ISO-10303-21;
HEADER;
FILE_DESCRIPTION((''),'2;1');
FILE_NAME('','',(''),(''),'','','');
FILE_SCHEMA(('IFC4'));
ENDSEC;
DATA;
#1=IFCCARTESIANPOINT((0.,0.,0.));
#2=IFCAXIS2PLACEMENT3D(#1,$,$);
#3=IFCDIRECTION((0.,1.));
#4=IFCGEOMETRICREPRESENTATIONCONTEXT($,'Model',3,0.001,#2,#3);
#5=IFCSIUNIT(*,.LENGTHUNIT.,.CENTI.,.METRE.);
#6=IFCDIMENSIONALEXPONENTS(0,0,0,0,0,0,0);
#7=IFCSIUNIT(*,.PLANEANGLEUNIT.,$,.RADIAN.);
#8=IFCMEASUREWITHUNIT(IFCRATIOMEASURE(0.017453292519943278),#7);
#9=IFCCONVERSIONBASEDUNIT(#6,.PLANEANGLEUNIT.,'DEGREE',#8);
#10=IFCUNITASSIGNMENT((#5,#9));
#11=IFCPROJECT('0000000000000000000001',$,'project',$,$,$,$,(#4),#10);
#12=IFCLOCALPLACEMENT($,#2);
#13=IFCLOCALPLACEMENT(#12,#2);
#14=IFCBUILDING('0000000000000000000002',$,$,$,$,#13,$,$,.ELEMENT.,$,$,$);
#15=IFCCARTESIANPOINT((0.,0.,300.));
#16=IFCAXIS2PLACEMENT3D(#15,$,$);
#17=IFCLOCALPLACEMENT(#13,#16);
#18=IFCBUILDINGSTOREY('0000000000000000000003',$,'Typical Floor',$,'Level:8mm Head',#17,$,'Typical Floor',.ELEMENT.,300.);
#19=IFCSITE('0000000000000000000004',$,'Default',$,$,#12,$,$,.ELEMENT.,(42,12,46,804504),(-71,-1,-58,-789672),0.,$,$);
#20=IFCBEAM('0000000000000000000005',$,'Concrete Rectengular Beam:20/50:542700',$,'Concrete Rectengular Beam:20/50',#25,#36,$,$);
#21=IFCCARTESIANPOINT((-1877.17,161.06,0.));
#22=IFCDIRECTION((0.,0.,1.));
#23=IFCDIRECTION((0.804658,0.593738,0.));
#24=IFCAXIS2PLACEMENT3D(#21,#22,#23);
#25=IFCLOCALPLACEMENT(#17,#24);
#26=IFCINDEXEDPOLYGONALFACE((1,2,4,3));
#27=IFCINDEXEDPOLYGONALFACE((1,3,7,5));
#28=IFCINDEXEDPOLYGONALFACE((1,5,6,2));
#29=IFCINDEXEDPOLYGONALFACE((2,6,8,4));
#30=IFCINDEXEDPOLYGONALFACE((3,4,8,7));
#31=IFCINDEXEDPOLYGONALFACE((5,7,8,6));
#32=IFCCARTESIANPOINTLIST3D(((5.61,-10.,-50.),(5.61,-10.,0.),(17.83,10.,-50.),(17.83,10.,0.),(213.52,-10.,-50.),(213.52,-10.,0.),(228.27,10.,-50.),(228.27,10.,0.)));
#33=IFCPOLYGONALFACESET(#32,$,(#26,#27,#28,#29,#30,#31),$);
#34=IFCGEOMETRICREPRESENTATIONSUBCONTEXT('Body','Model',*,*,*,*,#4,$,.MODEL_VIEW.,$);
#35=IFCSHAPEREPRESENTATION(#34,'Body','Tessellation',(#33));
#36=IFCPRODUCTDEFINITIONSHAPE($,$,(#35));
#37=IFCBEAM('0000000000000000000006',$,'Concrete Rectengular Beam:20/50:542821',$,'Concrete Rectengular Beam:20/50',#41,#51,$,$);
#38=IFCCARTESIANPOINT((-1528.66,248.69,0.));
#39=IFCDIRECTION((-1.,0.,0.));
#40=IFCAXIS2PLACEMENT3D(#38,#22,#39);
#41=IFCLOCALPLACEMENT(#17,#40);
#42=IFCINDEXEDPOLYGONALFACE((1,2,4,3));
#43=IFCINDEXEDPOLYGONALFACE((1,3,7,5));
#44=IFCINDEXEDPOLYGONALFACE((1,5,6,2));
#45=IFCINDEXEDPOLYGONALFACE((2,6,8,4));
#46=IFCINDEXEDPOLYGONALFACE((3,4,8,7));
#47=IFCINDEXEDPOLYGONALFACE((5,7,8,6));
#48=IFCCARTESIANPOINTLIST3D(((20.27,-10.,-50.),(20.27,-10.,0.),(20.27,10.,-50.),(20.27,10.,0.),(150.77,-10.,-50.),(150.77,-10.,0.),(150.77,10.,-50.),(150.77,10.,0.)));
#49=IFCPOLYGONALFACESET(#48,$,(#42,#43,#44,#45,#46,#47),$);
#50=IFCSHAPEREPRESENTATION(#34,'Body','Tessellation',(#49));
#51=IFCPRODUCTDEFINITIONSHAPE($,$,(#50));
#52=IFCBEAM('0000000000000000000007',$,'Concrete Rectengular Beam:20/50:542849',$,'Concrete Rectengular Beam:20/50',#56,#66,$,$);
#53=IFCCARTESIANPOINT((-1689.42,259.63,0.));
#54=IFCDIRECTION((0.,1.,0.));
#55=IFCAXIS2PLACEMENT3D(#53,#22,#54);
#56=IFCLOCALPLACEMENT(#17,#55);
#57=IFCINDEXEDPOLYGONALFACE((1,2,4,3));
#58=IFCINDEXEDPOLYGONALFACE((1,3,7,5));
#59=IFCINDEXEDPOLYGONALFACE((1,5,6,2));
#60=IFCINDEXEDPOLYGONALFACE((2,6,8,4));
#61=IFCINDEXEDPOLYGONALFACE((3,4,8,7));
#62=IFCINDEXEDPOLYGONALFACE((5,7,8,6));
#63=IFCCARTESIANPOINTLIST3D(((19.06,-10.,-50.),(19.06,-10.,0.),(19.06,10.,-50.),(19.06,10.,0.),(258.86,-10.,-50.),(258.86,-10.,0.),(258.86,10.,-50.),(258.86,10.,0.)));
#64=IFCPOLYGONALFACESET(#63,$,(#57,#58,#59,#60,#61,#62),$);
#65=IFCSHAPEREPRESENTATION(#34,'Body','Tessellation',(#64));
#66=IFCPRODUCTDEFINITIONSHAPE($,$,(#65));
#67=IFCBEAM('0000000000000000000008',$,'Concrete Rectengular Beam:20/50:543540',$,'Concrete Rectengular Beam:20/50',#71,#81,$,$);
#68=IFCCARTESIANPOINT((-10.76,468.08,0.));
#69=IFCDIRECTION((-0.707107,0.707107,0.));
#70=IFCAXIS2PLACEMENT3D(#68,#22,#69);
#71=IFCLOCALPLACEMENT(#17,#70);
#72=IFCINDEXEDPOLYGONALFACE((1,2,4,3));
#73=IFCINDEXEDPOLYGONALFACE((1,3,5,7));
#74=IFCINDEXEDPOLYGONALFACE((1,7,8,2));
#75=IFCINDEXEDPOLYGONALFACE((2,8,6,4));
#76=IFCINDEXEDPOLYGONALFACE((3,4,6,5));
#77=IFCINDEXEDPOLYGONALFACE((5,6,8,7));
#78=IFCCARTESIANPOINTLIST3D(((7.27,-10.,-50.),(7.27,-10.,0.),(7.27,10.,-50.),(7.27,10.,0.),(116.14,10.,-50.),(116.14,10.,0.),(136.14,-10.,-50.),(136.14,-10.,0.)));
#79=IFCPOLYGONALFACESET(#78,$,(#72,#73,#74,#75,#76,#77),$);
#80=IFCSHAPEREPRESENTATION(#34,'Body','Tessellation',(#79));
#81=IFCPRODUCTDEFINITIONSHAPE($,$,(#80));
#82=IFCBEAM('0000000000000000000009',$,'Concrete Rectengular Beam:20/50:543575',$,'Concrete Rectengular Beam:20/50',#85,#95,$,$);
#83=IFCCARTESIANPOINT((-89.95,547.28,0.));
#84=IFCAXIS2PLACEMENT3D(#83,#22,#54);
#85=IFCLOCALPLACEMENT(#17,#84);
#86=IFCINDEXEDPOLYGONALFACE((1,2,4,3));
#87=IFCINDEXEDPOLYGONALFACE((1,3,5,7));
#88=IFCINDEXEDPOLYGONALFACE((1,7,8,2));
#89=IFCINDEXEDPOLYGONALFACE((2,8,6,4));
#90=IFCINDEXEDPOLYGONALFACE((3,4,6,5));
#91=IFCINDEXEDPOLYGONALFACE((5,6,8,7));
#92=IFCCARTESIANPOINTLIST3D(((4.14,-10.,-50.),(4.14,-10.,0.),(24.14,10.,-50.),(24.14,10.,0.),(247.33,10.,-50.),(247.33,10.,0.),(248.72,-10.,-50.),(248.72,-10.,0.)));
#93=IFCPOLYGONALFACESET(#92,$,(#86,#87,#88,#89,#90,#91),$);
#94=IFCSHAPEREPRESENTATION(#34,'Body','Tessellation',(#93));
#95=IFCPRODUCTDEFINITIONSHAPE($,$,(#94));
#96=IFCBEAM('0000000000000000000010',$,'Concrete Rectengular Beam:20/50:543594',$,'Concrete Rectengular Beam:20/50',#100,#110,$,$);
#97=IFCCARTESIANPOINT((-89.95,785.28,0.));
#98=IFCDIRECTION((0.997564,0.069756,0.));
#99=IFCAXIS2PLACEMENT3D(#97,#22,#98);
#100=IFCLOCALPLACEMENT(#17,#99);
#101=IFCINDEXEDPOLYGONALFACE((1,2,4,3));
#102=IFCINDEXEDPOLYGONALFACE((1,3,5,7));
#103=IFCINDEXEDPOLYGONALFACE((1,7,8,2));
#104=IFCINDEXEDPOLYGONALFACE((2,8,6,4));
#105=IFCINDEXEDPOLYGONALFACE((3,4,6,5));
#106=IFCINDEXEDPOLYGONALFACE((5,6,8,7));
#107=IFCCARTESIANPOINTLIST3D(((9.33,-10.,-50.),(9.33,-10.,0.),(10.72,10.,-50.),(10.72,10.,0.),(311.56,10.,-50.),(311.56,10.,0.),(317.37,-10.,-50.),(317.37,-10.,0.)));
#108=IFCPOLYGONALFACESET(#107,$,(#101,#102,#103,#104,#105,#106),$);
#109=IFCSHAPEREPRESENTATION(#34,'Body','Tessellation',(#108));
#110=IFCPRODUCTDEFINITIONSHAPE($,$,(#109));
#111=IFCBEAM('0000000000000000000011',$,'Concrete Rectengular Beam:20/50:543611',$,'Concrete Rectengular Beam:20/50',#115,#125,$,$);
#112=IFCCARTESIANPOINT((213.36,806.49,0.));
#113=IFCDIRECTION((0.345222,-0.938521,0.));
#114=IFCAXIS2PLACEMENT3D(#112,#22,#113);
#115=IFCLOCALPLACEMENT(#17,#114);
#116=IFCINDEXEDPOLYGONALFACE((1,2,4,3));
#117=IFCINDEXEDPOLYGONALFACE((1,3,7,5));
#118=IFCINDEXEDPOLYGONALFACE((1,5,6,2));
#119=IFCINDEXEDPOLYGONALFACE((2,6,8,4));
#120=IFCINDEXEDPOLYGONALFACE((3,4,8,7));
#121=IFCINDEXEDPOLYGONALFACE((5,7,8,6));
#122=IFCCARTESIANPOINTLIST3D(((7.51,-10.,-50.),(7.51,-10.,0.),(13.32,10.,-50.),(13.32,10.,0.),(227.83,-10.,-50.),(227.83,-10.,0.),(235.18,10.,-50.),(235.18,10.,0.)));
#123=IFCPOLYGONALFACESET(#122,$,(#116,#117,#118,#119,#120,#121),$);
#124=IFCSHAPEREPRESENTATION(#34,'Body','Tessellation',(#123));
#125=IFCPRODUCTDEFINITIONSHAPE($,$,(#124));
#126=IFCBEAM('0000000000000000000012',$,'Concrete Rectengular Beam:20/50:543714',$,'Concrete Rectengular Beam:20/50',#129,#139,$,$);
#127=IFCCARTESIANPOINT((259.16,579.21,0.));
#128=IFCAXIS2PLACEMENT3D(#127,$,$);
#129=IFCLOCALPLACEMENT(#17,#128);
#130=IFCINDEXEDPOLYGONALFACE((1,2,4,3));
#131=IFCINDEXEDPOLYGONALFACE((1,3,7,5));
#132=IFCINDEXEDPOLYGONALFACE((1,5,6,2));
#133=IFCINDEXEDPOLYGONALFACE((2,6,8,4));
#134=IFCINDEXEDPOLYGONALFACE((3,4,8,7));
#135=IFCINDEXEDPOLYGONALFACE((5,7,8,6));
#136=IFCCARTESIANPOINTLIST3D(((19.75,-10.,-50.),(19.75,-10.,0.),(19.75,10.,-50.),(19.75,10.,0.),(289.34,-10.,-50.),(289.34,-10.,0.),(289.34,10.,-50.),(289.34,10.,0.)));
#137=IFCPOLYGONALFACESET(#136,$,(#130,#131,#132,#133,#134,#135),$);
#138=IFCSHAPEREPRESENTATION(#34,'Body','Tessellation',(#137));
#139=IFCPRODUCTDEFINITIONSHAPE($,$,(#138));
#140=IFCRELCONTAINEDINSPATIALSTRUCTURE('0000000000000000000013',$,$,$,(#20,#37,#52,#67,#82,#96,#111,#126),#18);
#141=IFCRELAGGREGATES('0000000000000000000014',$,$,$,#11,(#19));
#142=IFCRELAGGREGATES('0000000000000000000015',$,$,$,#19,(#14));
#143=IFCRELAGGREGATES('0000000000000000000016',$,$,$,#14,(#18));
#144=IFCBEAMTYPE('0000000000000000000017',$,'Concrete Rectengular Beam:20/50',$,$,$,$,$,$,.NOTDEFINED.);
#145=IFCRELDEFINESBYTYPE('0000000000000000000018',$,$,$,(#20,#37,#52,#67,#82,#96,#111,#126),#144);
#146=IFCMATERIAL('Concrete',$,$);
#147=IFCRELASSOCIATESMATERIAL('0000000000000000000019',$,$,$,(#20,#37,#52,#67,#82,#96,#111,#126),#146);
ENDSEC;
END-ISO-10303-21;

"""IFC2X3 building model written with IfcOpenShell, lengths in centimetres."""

from ifc_helpers import new_model, entity, si_unit, converted_unit, direction, frame, frame_2d, origin, place, context, subcontext, project, spatial, rectangle, extrude, clip, halfspace, material, type_object, element, save


model = new_model("IFC2X3")

# Units and contexts
model_context = context("Model", 3, precision=0.001, world=origin(), true_north=direction((0.0, 1.0)))
body_context = subcontext(model_context, "Body", "Model", "MODEL_VIEW")
ifc_project = project(units=[si_unit("LENGTHUNIT", "METRE", prefix="CENTI"), converted_unit("PLANEANGLEUNIT", "DEGREE", entity("IfcRatioMeasure", 0.017453292519943278), si_unit("PLANEANGLEUNIT", "RADIAN"), dimensions=[0, 0, 0, 0, 0, 0, 0])], contexts=[model_context])

# Site, building, storey
site_placement = place(None, origin())
site = spatial("IfcSite", under=ifc_project, at=site_placement, Name="Default", CompositionType="ELEMENT", RefLatitude=(42, 12, 46, 804504), RefLongitude=(-71, -1, -58, -789672), RefElevation=0.0)
building_placement = place(site_placement, origin())
building = spatial("IfcBuilding", under=site, at=building_placement, CompositionType="ELEMENT")
storey_placement = place(building_placement, frame((0.0, 0.0, 300.0)))
storey = spatial("IfcBuildingStorey", under=building, at=storey_placement, Name="Typical Floor", ObjectType="Level:8mm Head", LongName="Typical Floor", CompositionType="ELEMENT", Elevation=300.0)

# Beams
ifc_material = material(Name="Concrete")
beam_type_1 = type_object("IfcBeamType", Name="Concrete Rectengular Beam:20/50", PredefinedType="NOTDEFINED")
beam_1_placement = place(storey_placement, frame((-1877.17, 161.06, 0.0), z_axis=(0.0, 0.0, 1.0), x_axis=(0.804658, 0.593738, 0.0)))
element("IfcBeam", 1, at=beam_1_placement, inside=storey, type_object=beam_type_1, material=ifc_material, Name="Concrete Rectengular Beam:20/50:542700", ObjectType="Concrete Rectengular Beam:20/50", context=body_context, shape_type="SweptSolid", body=[
    clip(clip(extrude(rectangle(XDim=50.0, YDim=20.0, at=frame_2d((0.0, 0.0), x_axis=(1.0, 0.0))), frame((5.61, 0.0, -25.0), z_axis=(1.0, 0.0, 0.0), x_axis=(0.0, 0.0, -1.0)), (0.0, 0.0, 1.0), 222.66), halfspace(frame((3.42, -13.58, 0.0), z_axis=(-0.85332, 0.521387, 0.0), x_axis=(-0.521387, -0.85332, 0.0)), False)), halfspace(frame((354.49, 181.05, -50.0), z_axis=(0.804658, -0.593738, 0.0), x_axis=(-0.593738, -0.804658, 0.0)), False)),
])
beam_2_placement = place(storey_placement, frame((-1528.66, 248.69, 0.0), z_axis=(0.0, 0.0, 1.0), x_axis=(-1.0, 0.0, 0.0)))
element("IfcBeam", 2, at=beam_2_placement, inside=storey, type_object=beam_type_1, material=ifc_material, Name="Concrete Rectengular Beam:20/50:542821", ObjectType="Concrete Rectengular Beam:20/50", context=body_context, shape_type="SweptSolid", body=[
    extrude(rectangle(XDim=50.0, YDim=20.0, at=frame_2d((0.0, 0.0), x_axis=(1.0, 0.0))), frame((20.27, 0.0, -25.0), z_axis=(1.0, 0.0, 0.0), x_axis=(0.0, 0.0, -1.0)), (0.0, 0.0, 1.0), 130.5),
])
beam_3_placement = place(storey_placement, frame((-1689.42, 259.63, 0.0), z_axis=(0.0, 0.0, 1.0), x_axis=(0.0, 1.0, 0.0)))
element("IfcBeam", 3, at=beam_3_placement, inside=storey, type_object=beam_type_1, material=ifc_material, Name="Concrete Rectengular Beam:20/50:542849", ObjectType="Concrete Rectengular Beam:20/50", context=body_context, shape_type="SweptSolid", body=[
    extrude(rectangle(XDim=50.0, YDim=20.0, at=frame_2d((0.0, 0.0), x_axis=(1.0, 0.0))), frame((19.06, 0.0, -25.0), z_axis=(1.0, 0.0, 0.0), x_axis=(0.0, 0.0, -1.0)), (0.0, 0.0, 1.0), 239.79),
])
beam_4_placement = place(storey_placement, frame((-10.76, 468.08, 0.0), z_axis=(0.0, 0.0, 1.0), x_axis=(-0.707107, 0.707107, 0.0)))
element("IfcBeam", 4, at=beam_4_placement, inside=storey, type_object=beam_type_1, material=ifc_material, Name="Concrete Rectengular Beam:20/50:543540", ObjectType="Concrete Rectengular Beam:20/50", context=body_context, shape_type="SweptSolid", body=[
    clip(extrude(rectangle(XDim=50.0, YDim=20.0, at=frame_2d((0.0, 0.0), x_axis=(1.0, 0.0))), frame((7.27, 0.0, -25.0), z_axis=(1.0, 0.0, 0.0), x_axis=(0.0, 0.0, -1.0)), (0.0, 0.0, 1.0), 128.88), halfspace(frame((100.48, 25.66, 0.0), z_axis=(0.707107, 0.707107, 0.0), x_axis=(0.707107, -0.707107, 0.0)), False)),
])
beam_5_placement = place(storey_placement, frame((-89.95, 547.28, 0.0), z_axis=(0.0, 0.0, 1.0), x_axis=(0.0, 1.0, 0.0)))
element("IfcBeam", 5, at=beam_5_placement, inside=storey, type_object=beam_type_1, material=ifc_material, Name="Concrete Rectengular Beam:20/50:543575", ObjectType="Concrete Rectengular Beam:20/50", context=body_context, shape_type="SweptSolid", body=[
    clip(clip(extrude(rectangle(XDim=50.0, YDim=20.0, at=frame_2d((0.0, 0.0), x_axis=(1.0, 0.0))), frame((4.14, 0.0, -25.0), z_axis=(1.0, 0.0, 0.0), x_axis=(0.0, 0.0, -1.0)), (0.0, 0.0, 1.0), 244.58), halfspace(frame((1.17, -12.97, 0.0), z_axis=(-0.707107, 0.707107, 0.0), x_axis=(-0.707107, -0.707107, 0.0)), False)), halfspace(frame((247.1, 13.15, 0.0), z_axis=(0.997564, 0.069756, 0.0), x_axis=(0.069756, -0.997564, 0.0)), False)),
])
beam_6_placement = place(storey_placement, frame((-89.95, 785.28, 0.0), z_axis=(0.0, 0.0, 1.0), x_axis=(0.997564, 0.069756, 0.0)))
element("IfcBeam", 6, at=beam_6_placement, inside=storey, type_object=beam_type_1, material=ifc_material, Name="Concrete Rectengular Beam:20/50:543594", ObjectType="Concrete Rectengular Beam:20/50", context=body_context, shape_type="SweptSolid", body=[
    clip(clip(extrude(rectangle(XDim=50.0, YDim=20.0, at=frame_2d((0.0, 0.0), x_axis=(1.0, 0.0))), frame((9.33, 0.0, -25.0), z_axis=(1.0, 0.0, 0.0), x_axis=(0.0, 0.0, -1.0)), (0.0, 0.0, 1.0), 308.05), halfspace(frame((9.19, -11.92, 0.0), z_axis=(-0.997564, 0.069756, 0.0), x_axis=(-0.069756, -0.997564, 0.0)), False)), halfspace(frame((309.78, 16.15, 0.0), z_axis=(0.960316, 0.278913, 0.0), x_axis=(0.278913, -0.960316, 0.0)), False)),
])
beam_7_placement = place(storey_placement, frame((213.36, 806.49, 0.0), z_axis=(0.0, 0.0, 1.0), x_axis=(0.345222, -0.938521, 0.0)))
element("IfcBeam", 7, at=beam_7_placement, inside=storey, type_object=beam_type_1, material=ifc_material, Name="Concrete Rectengular Beam:20/50:543611", ObjectType="Concrete Rectengular Beam:20/50", context=body_context, shape_type="SweptSolid", body=[
    clip(clip(extrude(rectangle(XDim=50.0, YDim=20.0, at=frame_2d((0.0, 0.0), x_axis=(1.0, 0.0))), frame((7.51, 0.0, -25.0), z_axis=(1.0, 0.0, 0.0), x_axis=(0.0, 0.0, -1.0)), (0.0, 0.0, 1.0), 227.67), halfspace(frame((6.58, -13.2, 0.0), z_axis=(-0.960316, 0.278913, 0.0), x_axis=(-0.278913, -0.960316, 0.0)), False)), halfspace(frame((319.17, 238.33, -50.0), z_axis=(0.938521, -0.345222, 0.0), x_axis=(-0.345222, -0.938521, 0.0)), False)),
])
beam_8_placement = place(storey_placement, frame((259.16, 579.21, 0.0)))
element("IfcBeam", 8, at=beam_8_placement, inside=storey, type_object=beam_type_1, material=ifc_material, Name="Concrete Rectengular Beam:20/50:543714", ObjectType="Concrete Rectengular Beam:20/50", context=body_context, shape_type="SweptSolid", body=[
    extrude(rectangle(XDim=50.0, YDim=20.0, at=frame_2d((0.0, 0.0), x_axis=(1.0, 0.0))), frame((19.75, 0.0, -25.0), z_axis=(1.0, 0.0, 0.0), x_axis=(0.0, 0.0, -1.0)), (0.0, 0.0, 1.0), 269.59),
])

save(model, "model.ifc")
